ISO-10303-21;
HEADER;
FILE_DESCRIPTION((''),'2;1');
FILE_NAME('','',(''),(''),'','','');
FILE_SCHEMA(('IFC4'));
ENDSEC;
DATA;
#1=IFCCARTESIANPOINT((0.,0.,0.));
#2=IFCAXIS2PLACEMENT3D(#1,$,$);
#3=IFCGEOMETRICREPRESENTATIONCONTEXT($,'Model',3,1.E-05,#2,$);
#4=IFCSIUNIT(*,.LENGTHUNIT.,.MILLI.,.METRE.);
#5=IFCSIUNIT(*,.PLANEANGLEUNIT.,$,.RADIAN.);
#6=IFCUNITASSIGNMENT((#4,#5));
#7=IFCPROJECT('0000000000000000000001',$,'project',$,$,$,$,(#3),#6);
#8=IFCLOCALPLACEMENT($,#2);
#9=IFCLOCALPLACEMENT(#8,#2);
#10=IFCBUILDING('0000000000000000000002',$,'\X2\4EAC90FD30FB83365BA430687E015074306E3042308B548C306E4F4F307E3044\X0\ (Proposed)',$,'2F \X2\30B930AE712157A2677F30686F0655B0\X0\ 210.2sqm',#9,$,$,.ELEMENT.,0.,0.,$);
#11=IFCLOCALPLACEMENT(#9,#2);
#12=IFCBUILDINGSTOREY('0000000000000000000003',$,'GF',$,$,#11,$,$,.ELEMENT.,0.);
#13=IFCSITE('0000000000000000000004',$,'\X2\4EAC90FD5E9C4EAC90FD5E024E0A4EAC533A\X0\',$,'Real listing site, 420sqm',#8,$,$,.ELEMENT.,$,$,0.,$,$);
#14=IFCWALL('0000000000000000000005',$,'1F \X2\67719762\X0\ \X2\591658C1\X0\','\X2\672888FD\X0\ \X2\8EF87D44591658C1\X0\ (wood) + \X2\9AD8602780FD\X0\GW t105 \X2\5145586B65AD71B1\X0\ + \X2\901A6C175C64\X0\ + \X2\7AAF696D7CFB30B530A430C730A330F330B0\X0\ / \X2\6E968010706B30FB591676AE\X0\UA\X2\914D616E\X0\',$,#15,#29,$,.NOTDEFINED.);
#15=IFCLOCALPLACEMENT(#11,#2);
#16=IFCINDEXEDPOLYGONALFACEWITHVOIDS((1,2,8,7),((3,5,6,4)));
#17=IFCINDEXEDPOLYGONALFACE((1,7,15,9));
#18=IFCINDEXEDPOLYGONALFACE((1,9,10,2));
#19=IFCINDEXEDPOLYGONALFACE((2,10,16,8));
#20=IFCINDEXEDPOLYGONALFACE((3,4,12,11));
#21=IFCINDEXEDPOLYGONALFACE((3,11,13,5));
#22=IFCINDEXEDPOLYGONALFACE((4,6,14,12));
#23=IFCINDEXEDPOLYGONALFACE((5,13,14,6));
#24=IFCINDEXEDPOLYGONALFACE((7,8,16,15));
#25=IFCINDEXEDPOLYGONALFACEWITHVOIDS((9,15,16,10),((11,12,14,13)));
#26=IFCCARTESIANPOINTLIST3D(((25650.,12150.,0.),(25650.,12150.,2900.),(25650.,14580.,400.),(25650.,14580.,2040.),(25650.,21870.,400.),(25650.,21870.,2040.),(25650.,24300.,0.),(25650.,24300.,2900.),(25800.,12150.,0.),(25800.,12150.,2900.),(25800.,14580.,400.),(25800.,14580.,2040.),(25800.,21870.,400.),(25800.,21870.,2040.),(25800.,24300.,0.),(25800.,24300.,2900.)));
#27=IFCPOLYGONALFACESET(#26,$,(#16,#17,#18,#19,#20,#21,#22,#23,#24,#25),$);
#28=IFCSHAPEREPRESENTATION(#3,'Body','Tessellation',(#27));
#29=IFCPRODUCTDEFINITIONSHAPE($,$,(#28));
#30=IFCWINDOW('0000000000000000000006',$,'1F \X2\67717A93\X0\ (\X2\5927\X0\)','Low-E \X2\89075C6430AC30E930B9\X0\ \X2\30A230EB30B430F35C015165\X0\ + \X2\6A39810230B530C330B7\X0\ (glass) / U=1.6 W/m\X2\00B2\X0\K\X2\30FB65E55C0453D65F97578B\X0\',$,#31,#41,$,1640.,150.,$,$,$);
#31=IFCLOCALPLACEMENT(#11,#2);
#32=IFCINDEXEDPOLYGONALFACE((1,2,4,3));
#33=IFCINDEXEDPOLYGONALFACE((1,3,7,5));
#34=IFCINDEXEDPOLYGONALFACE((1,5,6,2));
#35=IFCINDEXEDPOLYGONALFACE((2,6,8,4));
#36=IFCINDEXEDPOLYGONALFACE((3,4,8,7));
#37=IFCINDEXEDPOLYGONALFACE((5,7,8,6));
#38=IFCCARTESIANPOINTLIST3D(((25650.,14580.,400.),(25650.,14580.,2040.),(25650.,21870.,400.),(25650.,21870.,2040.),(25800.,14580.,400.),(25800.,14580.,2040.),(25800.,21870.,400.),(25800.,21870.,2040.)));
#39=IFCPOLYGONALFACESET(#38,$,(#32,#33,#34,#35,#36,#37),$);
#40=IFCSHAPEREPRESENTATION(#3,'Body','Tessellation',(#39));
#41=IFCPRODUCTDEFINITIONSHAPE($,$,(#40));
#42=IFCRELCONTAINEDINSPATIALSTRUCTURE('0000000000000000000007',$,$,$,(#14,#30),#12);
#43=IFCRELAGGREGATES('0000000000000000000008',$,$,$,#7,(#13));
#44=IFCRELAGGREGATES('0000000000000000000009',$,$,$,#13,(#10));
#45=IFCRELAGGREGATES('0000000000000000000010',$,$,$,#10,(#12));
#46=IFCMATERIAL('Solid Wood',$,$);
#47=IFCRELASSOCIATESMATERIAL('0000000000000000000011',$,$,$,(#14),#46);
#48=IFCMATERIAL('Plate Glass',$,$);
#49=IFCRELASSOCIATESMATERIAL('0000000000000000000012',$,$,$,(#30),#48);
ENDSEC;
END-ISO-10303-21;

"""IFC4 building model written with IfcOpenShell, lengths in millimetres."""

from ifc_helpers import new_model, si_unit, frame, frame_2d, origin, place, context, project, spatial, rectangle, extrude, material, element, fill, save


model = new_model("IFC4")

# Units and contexts
model_context = context("Model", 3, precision=1e-05, world=origin())
ifc_project = project(units=[si_unit("LENGTHUNIT", "METRE", prefix="MILLI"), si_unit("PLANEANGLEUNIT", "RADIAN")], contexts=[model_context])

# Site, building, storey
site_placement = place(None, origin())
site = spatial("IfcSite", under=ifc_project, at=site_placement, Name="京都府京都市上京区", ObjectType="Real listing site, 420sqm", CompositionType="ELEMENT", RefElevation=0.0)
building_placement = place(site_placement, origin())
building = spatial("IfcBuilding", under=site, at=building_placement, Name="京都・茶室と縁側のある和の住まい (Proposed)", ObjectType="2F スギ無垢板と漆喰 210.2sqm", CompositionType="ELEMENT", ElevationOfRefHeight=0.0, ElevationOfTerrain=0.0)
storey_placement = place(building_placement, origin())
storey = spatial("IfcBuildingStorey", under=building, at=storey_placement, Name="GF", CompositionType="ELEMENT", Elevation=0.0)

# Shared definitions
ifc_material_1 = material(Name="Solid Wood")

# Wall, opening, window
wall_1_placement = place(storey_placement, frame((12825.0, 6075.0, 0.0)))
wall_1 = element("IfcWall", 1, at=wall_1_placement, inside=storey, material=ifc_material_1, Name="1F 東面 外壁", Description="木製 軸組外壁 (wood) + 高性能GW t105 充填断熱 + 通気層 + 窯業系サイディング / 準耐火・外皮UA配慮", PredefinedType="NOTDEFINED", context=model_context, shape_type="SweptSolid", body=[
    extrude(rectangle(XDim=150.0, YDim=12150.0, at=frame_2d((75.0, 6075.0))), frame((12825.0, 6075.0, 0.0)), (0.0, 0.0, 1.0), 2900.0),
])
opening_1_placement = place(storey_placement, frame((12825.0, 7290.0, 200.0)))
opening_1 = element("IfcOpeningElement", 2, at=opening_1_placement, cuts=wall_1, PredefinedType="NOTDEFINED", context=model_context, shape_type="SweptSolid", body=[
    extrude(rectangle(XDim=150.0, YDim=7290.0, at=frame_2d((75.0, 3645.0))), frame((12825.0, 7290.0, 200.0)), (0.0, 0.0, 1.0), 1640.0),
])
ifc_material_2 = material(Name="Plate Glass")
window_1_placement = place(storey_placement, frame((12825.0, 7290.0, 200.0)))
window_1 = element("IfcWindow", 3, at=window_1_placement, inside=storey, material=ifc_material_2, Name="1F 東窓 (大)", Description="Low-E 複層ガラス アルゴン封入 + 樹脂サッシ (glass) / U=1.6 W/m²K・日射取得型", OverallHeight=1640.0, OverallWidth=150.0, context=model_context, shape_type="SweptSolid", body=[
    extrude(rectangle(XDim=150.0, YDim=7290.0, at=frame_2d((75.0, 3645.0))), frame((12825.0, 7290.0, 200.0)), (0.0, 0.0, 1.0), 1640.0),
])
fill(opening_1, window_1)

save(model, "model.ifc")
